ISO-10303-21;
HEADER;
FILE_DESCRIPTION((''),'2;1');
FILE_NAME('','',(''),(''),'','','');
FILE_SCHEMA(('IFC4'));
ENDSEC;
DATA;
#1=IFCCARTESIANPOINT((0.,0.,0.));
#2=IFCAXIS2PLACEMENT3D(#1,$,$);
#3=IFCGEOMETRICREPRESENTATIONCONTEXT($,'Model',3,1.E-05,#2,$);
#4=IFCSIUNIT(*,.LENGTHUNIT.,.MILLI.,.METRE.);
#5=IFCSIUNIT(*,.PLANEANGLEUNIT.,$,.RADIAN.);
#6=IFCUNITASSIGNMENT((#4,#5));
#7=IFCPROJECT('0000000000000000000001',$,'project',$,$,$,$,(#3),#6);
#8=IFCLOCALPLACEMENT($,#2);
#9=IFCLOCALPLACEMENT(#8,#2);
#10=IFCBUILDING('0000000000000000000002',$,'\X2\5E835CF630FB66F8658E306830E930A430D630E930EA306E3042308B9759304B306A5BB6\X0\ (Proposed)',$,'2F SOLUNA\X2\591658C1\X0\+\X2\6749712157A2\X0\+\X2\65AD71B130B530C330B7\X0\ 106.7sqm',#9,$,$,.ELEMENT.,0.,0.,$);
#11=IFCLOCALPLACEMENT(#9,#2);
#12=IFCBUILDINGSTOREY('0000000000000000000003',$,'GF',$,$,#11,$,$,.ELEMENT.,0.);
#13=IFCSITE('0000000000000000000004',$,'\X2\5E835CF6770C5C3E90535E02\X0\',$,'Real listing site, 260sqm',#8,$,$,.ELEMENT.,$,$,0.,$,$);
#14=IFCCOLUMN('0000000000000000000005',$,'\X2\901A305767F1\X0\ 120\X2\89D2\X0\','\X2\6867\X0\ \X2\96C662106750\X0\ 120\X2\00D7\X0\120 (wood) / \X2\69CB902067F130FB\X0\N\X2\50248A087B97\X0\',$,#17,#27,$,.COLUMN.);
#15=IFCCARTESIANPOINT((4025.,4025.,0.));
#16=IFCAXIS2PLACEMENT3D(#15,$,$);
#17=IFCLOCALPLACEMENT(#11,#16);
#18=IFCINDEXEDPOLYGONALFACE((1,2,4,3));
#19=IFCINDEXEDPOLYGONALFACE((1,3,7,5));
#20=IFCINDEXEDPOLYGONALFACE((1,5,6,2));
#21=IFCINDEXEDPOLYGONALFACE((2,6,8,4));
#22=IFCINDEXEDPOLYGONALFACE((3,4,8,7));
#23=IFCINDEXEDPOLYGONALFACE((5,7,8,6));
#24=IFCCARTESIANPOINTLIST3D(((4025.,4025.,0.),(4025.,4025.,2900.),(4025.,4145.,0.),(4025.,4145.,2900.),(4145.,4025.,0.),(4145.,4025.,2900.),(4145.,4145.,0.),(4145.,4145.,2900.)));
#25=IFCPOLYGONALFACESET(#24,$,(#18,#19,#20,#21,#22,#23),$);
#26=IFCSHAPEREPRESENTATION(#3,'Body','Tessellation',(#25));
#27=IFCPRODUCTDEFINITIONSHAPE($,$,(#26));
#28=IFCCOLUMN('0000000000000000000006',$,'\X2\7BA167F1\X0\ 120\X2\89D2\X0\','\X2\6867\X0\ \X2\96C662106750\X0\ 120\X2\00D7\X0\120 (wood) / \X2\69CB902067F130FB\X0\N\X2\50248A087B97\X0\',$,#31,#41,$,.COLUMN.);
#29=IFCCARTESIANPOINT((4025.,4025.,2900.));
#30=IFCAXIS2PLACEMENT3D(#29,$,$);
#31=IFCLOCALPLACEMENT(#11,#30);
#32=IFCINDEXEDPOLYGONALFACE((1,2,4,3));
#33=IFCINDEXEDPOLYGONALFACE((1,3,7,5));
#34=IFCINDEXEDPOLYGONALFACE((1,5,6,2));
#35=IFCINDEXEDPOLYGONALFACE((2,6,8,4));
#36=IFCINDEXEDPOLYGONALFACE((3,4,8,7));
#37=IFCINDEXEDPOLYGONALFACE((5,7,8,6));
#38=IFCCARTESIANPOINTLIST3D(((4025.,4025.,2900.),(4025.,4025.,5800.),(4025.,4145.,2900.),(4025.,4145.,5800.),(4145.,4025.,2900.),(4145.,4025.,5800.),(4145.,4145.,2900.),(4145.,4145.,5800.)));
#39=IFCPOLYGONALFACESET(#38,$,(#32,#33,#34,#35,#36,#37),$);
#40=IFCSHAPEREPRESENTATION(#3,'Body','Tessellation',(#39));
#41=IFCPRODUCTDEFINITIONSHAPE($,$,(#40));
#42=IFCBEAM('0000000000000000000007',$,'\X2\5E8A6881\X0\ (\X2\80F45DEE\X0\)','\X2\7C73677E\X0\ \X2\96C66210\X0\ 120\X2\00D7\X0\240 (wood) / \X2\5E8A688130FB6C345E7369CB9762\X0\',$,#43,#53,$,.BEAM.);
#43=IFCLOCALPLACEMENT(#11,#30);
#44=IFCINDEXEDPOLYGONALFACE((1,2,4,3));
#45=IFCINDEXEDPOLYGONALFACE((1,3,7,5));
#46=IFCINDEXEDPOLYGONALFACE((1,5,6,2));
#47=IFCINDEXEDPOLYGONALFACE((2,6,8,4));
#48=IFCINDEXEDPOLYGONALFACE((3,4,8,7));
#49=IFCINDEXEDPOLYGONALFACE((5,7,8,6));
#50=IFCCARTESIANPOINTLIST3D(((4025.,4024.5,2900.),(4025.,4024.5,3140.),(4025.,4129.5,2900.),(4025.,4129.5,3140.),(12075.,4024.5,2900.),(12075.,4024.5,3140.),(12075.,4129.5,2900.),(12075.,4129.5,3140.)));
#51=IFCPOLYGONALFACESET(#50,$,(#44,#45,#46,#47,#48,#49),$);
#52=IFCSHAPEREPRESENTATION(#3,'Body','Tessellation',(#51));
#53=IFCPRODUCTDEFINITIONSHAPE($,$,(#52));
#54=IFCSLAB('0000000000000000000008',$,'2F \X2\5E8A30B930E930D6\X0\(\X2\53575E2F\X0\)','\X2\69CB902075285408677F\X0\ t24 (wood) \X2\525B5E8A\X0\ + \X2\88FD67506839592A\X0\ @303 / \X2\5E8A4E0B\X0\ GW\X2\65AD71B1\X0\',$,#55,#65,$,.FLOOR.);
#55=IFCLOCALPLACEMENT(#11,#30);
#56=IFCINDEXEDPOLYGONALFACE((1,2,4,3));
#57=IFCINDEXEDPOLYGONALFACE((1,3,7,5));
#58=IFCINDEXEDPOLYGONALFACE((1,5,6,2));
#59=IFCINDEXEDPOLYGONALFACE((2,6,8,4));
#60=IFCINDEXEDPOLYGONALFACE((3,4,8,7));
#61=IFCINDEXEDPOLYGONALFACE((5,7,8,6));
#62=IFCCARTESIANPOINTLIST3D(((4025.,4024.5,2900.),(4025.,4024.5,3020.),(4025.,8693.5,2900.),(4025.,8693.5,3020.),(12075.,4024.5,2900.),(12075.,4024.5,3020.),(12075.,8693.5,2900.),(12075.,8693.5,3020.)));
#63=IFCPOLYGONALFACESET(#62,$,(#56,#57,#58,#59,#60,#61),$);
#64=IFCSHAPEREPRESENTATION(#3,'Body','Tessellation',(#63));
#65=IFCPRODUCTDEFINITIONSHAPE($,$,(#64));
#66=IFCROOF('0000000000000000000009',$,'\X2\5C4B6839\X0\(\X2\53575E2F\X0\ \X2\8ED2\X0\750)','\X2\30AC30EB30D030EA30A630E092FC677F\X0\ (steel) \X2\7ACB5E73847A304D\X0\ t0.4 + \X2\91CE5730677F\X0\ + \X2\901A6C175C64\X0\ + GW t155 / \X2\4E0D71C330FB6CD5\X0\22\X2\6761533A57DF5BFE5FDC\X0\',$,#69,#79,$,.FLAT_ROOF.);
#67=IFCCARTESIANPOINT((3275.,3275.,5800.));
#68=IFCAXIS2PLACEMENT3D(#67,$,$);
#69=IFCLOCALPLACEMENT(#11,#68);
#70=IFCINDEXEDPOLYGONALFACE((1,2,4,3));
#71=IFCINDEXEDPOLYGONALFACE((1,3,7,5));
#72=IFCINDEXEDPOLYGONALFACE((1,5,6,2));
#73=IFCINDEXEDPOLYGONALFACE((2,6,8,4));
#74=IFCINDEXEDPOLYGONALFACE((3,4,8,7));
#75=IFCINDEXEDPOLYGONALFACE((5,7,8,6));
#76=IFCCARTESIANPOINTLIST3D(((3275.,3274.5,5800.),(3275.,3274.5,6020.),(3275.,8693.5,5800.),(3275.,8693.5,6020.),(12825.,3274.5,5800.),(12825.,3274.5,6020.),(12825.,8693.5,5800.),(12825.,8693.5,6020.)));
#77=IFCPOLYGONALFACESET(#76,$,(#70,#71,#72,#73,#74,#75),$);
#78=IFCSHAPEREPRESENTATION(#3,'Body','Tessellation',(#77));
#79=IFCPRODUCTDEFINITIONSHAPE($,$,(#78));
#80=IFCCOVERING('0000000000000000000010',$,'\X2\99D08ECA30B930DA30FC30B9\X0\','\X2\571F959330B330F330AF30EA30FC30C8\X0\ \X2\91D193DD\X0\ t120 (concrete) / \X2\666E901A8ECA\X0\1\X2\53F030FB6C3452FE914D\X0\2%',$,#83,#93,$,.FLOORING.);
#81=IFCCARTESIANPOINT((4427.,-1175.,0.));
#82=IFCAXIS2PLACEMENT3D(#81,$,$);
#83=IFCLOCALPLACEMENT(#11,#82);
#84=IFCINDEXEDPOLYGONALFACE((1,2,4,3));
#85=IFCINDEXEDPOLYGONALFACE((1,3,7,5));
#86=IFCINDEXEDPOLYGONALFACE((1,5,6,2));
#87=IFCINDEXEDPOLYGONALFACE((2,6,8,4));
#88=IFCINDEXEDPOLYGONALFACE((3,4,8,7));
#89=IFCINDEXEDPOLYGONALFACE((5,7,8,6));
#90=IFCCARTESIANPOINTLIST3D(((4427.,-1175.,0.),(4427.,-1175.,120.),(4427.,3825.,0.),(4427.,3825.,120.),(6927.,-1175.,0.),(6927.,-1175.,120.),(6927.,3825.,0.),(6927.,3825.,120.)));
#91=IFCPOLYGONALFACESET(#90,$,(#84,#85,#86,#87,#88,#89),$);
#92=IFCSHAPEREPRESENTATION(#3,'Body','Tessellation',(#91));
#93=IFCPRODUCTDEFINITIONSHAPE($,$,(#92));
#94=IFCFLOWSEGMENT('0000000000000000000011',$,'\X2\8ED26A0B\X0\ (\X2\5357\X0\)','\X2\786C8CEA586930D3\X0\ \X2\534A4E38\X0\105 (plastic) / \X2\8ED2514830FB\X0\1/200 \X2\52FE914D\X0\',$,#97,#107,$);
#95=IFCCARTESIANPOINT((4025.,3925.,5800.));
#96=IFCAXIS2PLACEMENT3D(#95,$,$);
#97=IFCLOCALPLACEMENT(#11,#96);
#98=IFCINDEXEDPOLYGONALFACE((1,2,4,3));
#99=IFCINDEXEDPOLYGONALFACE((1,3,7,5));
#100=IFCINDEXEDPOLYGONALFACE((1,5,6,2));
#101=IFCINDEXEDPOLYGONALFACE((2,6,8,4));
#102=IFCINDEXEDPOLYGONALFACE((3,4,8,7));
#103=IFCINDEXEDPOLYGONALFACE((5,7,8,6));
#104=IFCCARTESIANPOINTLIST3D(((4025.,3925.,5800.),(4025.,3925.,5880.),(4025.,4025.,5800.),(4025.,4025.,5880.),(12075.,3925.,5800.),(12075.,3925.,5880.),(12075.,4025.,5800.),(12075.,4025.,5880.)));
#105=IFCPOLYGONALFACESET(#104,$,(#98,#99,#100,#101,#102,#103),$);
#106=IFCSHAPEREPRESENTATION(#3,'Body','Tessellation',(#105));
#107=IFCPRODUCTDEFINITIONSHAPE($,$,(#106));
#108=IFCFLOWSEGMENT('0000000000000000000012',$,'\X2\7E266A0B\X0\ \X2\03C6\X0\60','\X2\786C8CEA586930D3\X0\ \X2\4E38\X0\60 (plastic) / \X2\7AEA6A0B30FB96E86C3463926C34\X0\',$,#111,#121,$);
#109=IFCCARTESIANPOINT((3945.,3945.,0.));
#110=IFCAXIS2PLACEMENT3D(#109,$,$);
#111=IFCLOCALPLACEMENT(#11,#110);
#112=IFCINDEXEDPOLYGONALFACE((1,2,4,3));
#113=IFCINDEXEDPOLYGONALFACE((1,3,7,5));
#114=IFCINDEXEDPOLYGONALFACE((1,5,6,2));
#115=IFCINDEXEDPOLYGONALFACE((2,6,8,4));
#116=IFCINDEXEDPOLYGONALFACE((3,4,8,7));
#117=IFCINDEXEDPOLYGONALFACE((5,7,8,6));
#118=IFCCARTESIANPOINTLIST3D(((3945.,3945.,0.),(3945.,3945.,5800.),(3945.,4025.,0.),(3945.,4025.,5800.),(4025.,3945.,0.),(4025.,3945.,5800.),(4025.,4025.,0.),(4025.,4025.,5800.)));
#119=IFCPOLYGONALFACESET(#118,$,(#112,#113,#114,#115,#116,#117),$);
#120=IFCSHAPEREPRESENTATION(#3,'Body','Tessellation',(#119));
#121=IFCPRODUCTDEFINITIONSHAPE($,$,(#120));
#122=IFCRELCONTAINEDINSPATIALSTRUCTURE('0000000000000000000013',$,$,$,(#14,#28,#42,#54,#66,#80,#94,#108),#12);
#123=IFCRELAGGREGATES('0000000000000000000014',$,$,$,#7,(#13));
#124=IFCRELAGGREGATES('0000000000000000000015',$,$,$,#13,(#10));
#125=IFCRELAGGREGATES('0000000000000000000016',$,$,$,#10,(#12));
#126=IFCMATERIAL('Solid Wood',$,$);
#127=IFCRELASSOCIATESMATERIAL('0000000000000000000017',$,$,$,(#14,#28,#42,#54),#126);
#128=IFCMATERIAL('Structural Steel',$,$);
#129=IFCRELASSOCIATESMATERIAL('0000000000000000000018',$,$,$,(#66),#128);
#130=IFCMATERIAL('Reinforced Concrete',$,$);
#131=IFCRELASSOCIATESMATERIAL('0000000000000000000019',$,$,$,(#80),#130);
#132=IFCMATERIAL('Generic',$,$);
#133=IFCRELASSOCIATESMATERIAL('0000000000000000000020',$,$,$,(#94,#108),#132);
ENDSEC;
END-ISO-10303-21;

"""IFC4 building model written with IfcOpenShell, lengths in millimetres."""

from ifc_helpers import new_model, si_unit, frame, frame_2d, origin, place, context, project, spatial, rectangle, extrude, material, element, save


model = new_model("IFC4")

# Units and contexts
model_context = context("Model", 3, precision=1e-05, world=origin())
ifc_project = project(units=[si_unit("LENGTHUNIT", "METRE", prefix="MILLI"), si_unit("PLANEANGLEUNIT", "RADIAN")], contexts=[model_context])

# Site, building, storey
site_placement = place(None, origin())
site = spatial("IfcSite", under=ifc_project, at=site_placement, Name="広島県尾道市", ObjectType="Real listing site, 260sqm", CompositionType="ELEMENT", RefElevation=0.0)
building_placement = place(site_placement, origin())
building = spatial("IfcBuilding", under=site, at=building_placement, Name="広島・書斎とライブラリのある静かな家 (Proposed)", ObjectType="2F SOLUNA外壁+杉無垢+断熱サッシ 106.7sqm", CompositionType="ELEMENT", ElevationOfRefHeight=0.0, ElevationOfTerrain=0.0)
storey_placement = place(building_placement, origin())
storey = spatial("IfcBuildingStorey", under=building, at=storey_placement, Name="GF", CompositionType="ELEMENT", Elevation=0.0)

# Columns
ifc_material_1 = material(Name="Solid Wood")
column_1_placement = place(storey_placement, frame((4025.0, 4025.0, 0.0)))
element("IfcColumn", 1, at=column_1_placement, inside=storey, material=ifc_material_1, Name="通し柱 120角", Description="桧 集成材 120×120 (wood) / 構造柱・N値計算", PredefinedType="COLUMN", context=model_context, shape_type="SweptSolid", body=[
    extrude(rectangle(XDim=120.0, YDim=120.0, at=frame_2d((60.0, 60.0))), frame((4025.0, 4025.0, 0.0)), (0.0, 0.0, 1.0), 2900.0),
])
column_2_placement = place(storey_placement, frame((4025.0, 4025.0, 2900.0)))
element("IfcColumn", 2, at=column_2_placement, inside=storey, material=ifc_material_1, Name="管柱 120角", Description="桧 集成材 120×120 (wood) / 構造柱・N値計算", PredefinedType="COLUMN", context=model_context, shape_type="SweptSolid", body=[
    extrude(rectangle(XDim=120.0, YDim=120.0, at=frame_2d((60.0, 60.0))), frame((4025.0, 4025.0, 2900.0)), (0.0, 0.0, 1.0), 2900.0),
])

# Beam
beam_1_placement = place(storey_placement, frame((4025.0, 4025.0, 2900.0)))
element("IfcBeam", 3, at=beam_1_placement, inside=storey, material=ifc_material_1, Name="床梁 (胴差)", Description="米松 集成 120×240 (wood) / 床梁・水平構面", PredefinedType="BEAM", context=model_context, shape_type="SweptSolid", body=[
    extrude(rectangle(XDim=8050.0, YDim=105.0, at=frame_2d((4025.0, 52.0))), frame((4025.0, 4025.0, 2900.0)), (0.0, 0.0, 1.0), 240.0),
])

# Slab
ifc_material_2 = material(Name="Reinforced Concrete")
slab_1_placement = place(storey_placement, frame((4025.0, 4025.0, 2900.0)))
element("IfcSlab", 4, at=slab_1_placement, inside=storey, material=ifc_material_1, Name="2F 床スラブ(南帯)", Description="構造用合板 t24 (wood) 剛床 + 製材根太 @303 / 床下 GW断熱", PredefinedType="FLOOR", context=model_context, shape_type="SweptSolid", body=[
    extrude(rectangle(XDim=8050.0, YDim=4669.0, at=frame_2d((4025.0, 2334.0))), frame((4025.0, 4025.0, 2900.0)), (0.0, 0.0, 1.0), 120.0),
])

# Roof
ifc_material_3 = material(Name="Structural Steel")
for number, where, name in (
    (5, (3275.0, 3275.0, 5800.0), "屋根(南帯 軒750)"),
):
    element("IfcRoof", number, at=place(storey_placement, frame(where)), inside=storey, material=ifc_material_3, Name=name, Description="ガルバリウム鋼板 (steel) 立平葺き t0.4 + 野地板 + 通気層 + GW t155 / 不燃・法22条区域対応", PredefinedType="FLAT_ROOF", context=model_context, shape_type="SweptSolid", body=[
        extrude(rectangle(XDim=9550.0, YDim=5419.0, at=frame_2d((4775.0, 2709.0))), frame((3275.0, 3275.0, 5800.0)), (0.0, 0.0, 1.0), 220.0),
    ])

# Covering
covering_placement = place(storey_placement, frame((4427.0, -1175.0, 0.0)))
element("IfcCovering", 6, at=covering_placement, inside=storey, material=ifc_material_2, Name="駐車スペース", Description="土間コンクリート 金鏝 t120 (concrete) / 普通車1台・水勾配2%", PredefinedType="FLOORING", context=model_context, shape_type="SweptSolid", body=[
    extrude(rectangle(XDim=2500.0, YDim=5000.0, at=frame_2d((1250.0, 2500.0))), frame((4427.0, -1175.0, 0.0)), (0.0, 0.0, 1.0), 120.0),
])

# Flow segments
ifc_material_4 = material(Name="Generic")
flow_segment_1_placement = place(storey_placement, frame((4025.0, 3925.0, 5800.0)))
element("IfcFlowSegment", 7, at=flow_segment_1_placement, inside=storey, material=ifc_material_4, Name="軒樋 (南)", Description="硬質塩ビ 半丸105 (plastic) / 軒先・1/200 勾配", context=model_context, shape_type="SweptSolid", body=[
    extrude(rectangle(XDim=8050.0, YDim=100.0, at=frame_2d((4025.0, 50.0))), frame((4025.0, 3925.0, 5800.0)), (0.0, 0.0, 1.0), 80.0),
])
flow_segment_2_placement = place(storey_placement, frame((3945.0, 3945.0, 0.0)))
element("IfcFlowSegment", 8, at=flow_segment_2_placement, inside=storey, material=ifc_material_4, Name="縦樋 φ60", Description="硬質塩ビ 丸60 (plastic) / 竪樋・雨水排水", context=model_context, shape_type="SweptSolid", body=[
    extrude(rectangle(XDim=80.0, YDim=80.0, at=frame_2d((40.0, 40.0))), frame((3945.0, 3945.0, 0.0)), (0.0, 0.0, 1.0), 5800.0),
])

save(model, "model.ifc")
